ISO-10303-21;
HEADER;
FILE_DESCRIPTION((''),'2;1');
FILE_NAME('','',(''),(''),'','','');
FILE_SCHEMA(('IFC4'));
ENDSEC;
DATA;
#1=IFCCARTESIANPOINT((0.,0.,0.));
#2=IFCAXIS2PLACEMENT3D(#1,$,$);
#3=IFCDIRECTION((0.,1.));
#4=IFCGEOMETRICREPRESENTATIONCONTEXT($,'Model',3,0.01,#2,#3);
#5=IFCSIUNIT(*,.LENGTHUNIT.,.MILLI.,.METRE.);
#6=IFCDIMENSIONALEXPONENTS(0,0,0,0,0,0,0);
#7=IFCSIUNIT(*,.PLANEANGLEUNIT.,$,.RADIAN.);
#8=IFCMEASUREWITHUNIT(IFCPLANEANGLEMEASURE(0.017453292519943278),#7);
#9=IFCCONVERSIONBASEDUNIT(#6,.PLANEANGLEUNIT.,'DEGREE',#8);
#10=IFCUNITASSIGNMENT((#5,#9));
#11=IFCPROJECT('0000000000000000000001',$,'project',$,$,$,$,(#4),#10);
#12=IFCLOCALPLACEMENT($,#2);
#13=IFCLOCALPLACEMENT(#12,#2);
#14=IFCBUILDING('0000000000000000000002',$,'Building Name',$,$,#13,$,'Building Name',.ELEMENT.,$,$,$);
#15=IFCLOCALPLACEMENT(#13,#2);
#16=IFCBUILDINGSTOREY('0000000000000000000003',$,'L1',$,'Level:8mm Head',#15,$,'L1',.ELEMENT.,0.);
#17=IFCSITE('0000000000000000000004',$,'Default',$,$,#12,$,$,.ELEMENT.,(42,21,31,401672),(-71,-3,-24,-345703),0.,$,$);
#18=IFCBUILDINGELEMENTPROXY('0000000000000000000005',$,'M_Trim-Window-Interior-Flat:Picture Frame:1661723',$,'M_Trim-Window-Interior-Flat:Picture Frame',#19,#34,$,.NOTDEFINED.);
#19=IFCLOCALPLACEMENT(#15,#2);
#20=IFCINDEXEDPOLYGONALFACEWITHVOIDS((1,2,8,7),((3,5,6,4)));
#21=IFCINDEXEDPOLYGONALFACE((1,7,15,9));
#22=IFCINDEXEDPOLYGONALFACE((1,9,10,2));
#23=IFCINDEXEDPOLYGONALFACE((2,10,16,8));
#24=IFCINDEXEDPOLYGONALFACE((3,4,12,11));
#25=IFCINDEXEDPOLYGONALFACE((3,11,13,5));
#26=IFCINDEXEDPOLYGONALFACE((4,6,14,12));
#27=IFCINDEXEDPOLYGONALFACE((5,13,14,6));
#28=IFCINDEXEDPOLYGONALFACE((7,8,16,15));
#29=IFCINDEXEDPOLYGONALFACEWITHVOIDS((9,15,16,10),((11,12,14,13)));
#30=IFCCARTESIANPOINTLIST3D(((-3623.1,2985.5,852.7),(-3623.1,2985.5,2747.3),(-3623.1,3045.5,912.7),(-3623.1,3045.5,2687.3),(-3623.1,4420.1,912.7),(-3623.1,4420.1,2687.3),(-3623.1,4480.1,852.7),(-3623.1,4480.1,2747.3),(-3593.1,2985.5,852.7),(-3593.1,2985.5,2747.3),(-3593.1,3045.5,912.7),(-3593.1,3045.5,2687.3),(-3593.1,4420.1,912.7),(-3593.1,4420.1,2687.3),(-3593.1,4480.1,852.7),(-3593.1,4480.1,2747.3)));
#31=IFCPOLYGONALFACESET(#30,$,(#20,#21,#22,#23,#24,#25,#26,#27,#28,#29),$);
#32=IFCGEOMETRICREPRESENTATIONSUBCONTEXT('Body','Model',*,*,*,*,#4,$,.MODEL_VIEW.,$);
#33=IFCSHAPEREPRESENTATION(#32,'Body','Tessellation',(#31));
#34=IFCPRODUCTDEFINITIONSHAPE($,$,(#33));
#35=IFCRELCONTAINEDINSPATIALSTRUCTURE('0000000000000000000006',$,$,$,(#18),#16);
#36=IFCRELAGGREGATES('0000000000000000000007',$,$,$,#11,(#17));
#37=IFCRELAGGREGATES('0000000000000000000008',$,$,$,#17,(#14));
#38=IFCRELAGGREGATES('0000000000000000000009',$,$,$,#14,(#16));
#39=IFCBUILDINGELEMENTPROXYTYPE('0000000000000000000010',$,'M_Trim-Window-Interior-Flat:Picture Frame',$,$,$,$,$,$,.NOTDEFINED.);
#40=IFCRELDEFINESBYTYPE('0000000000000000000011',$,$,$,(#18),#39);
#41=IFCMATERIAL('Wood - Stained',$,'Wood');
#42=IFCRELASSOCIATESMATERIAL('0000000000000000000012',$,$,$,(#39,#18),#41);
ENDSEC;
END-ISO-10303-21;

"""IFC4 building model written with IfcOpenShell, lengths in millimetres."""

from ifc_helpers import new_model, entity, si_unit, converted_unit, direction, frame, origin, place, context, subcontext, project, spatial, indexed_curve, outline, extrude, source, transform, mapped, material, type_object, type_shapes, element, save


model = new_model("IFC4")

# Units and contexts
model_context = context("Model", 3, precision=0.01, world=origin(), true_north=direction((0.0, 1.0)))
body_context = subcontext(model_context, "Body", "Model", "MODEL_VIEW")
ifc_project = project(units=[si_unit("LENGTHUNIT", "METRE", prefix="MILLI"), converted_unit("PLANEANGLEUNIT", "DEGREE", entity("IfcPlaneAngleMeasure", 0.017453292519943278), si_unit("PLANEANGLEUNIT", "RADIAN"), dimensions=[0, 0, 0, 0, 0, 0, 0])], contexts=[model_context])

# Site, building, storey
site_placement = place(None, origin())
site = spatial("IfcSite", under=ifc_project, at=site_placement, Name="Default", CompositionType="ELEMENT", RefLatitude=(42, 21, 31, 401672), RefLongitude=(-71, -3, -24, -345703), RefElevation=0.0)
building_placement = place(site_placement, origin())
building = spatial("IfcBuilding", under=site, at=building_placement, Name="Building Name", LongName="Building Name", CompositionType="ELEMENT")
storey_placement = place(building_placement, origin())
storey = spatial("IfcBuildingStorey", under=building, at=storey_placement, Name="L1", ObjectType="Level:8mm Head", LongName="L1", CompositionType="ELEMENT", Elevation=0.0)

# Building element proxy
ifc_material_1 = material(Name="Wood - Stained", Category="Wood")
building_element_proxy_type_1 = type_object("IfcBuildingElementProxyType", Name="M_Trim-Window-Interior-Flat:Picture Frame", PredefinedType="NOTDEFINED", material=ifc_material_1)
shared_shape_1 = source(origin(), body_context, "Body", "SweptSolid", [
    extrude(outline(indexed_curve([(-747.3, -947.3), (747.3, -947.3), (747.3, 947.3), (-747.3, 947.3), (-747.3, -947.3)], self_intersect=False), holes=[indexed_curve([(-687.3, -887.3), (-687.3, 887.3), (687.3, 887.3), (687.3, -887.3), (-687.3, -887.3)], self_intersect=False)]), frame((0.0, -900.0, 0.0), z_axis=(0.0, 0.0, 1.0), x_axis=(-1.0, 0.0, 0.0)), (0.0, 0.0, 1.0), 30.0),
])
type_shapes(building_element_proxy_type_1, [shared_shape_1])
for number, where, z_axis, x_axis, name in (
    (1, (-3623.1, 3732.8, 2700.0), (1.0, 0.0, 0.0), (0.0, 1.0, 0.0), "M_Trim-Window-Interior-Flat:Picture Frame:1661723"),
):
    element("IfcBuildingElementProxy", number, at=place(storey_placement, frame(where, z_axis=z_axis, x_axis=x_axis)), inside=storey, type_object=building_element_proxy_type_1, material=ifc_material_1, Name=name, ObjectType="M_Trim-Window-Interior-Flat:Picture Frame", PredefinedType="NOTDEFINED", context=body_context, shape_type="MappedRepresentation", body=[
        mapped(shared_shape_1, transform((0.0, 0.0, 0.0), scale=1.0)),
    ])

save(model, "model.ifc")
